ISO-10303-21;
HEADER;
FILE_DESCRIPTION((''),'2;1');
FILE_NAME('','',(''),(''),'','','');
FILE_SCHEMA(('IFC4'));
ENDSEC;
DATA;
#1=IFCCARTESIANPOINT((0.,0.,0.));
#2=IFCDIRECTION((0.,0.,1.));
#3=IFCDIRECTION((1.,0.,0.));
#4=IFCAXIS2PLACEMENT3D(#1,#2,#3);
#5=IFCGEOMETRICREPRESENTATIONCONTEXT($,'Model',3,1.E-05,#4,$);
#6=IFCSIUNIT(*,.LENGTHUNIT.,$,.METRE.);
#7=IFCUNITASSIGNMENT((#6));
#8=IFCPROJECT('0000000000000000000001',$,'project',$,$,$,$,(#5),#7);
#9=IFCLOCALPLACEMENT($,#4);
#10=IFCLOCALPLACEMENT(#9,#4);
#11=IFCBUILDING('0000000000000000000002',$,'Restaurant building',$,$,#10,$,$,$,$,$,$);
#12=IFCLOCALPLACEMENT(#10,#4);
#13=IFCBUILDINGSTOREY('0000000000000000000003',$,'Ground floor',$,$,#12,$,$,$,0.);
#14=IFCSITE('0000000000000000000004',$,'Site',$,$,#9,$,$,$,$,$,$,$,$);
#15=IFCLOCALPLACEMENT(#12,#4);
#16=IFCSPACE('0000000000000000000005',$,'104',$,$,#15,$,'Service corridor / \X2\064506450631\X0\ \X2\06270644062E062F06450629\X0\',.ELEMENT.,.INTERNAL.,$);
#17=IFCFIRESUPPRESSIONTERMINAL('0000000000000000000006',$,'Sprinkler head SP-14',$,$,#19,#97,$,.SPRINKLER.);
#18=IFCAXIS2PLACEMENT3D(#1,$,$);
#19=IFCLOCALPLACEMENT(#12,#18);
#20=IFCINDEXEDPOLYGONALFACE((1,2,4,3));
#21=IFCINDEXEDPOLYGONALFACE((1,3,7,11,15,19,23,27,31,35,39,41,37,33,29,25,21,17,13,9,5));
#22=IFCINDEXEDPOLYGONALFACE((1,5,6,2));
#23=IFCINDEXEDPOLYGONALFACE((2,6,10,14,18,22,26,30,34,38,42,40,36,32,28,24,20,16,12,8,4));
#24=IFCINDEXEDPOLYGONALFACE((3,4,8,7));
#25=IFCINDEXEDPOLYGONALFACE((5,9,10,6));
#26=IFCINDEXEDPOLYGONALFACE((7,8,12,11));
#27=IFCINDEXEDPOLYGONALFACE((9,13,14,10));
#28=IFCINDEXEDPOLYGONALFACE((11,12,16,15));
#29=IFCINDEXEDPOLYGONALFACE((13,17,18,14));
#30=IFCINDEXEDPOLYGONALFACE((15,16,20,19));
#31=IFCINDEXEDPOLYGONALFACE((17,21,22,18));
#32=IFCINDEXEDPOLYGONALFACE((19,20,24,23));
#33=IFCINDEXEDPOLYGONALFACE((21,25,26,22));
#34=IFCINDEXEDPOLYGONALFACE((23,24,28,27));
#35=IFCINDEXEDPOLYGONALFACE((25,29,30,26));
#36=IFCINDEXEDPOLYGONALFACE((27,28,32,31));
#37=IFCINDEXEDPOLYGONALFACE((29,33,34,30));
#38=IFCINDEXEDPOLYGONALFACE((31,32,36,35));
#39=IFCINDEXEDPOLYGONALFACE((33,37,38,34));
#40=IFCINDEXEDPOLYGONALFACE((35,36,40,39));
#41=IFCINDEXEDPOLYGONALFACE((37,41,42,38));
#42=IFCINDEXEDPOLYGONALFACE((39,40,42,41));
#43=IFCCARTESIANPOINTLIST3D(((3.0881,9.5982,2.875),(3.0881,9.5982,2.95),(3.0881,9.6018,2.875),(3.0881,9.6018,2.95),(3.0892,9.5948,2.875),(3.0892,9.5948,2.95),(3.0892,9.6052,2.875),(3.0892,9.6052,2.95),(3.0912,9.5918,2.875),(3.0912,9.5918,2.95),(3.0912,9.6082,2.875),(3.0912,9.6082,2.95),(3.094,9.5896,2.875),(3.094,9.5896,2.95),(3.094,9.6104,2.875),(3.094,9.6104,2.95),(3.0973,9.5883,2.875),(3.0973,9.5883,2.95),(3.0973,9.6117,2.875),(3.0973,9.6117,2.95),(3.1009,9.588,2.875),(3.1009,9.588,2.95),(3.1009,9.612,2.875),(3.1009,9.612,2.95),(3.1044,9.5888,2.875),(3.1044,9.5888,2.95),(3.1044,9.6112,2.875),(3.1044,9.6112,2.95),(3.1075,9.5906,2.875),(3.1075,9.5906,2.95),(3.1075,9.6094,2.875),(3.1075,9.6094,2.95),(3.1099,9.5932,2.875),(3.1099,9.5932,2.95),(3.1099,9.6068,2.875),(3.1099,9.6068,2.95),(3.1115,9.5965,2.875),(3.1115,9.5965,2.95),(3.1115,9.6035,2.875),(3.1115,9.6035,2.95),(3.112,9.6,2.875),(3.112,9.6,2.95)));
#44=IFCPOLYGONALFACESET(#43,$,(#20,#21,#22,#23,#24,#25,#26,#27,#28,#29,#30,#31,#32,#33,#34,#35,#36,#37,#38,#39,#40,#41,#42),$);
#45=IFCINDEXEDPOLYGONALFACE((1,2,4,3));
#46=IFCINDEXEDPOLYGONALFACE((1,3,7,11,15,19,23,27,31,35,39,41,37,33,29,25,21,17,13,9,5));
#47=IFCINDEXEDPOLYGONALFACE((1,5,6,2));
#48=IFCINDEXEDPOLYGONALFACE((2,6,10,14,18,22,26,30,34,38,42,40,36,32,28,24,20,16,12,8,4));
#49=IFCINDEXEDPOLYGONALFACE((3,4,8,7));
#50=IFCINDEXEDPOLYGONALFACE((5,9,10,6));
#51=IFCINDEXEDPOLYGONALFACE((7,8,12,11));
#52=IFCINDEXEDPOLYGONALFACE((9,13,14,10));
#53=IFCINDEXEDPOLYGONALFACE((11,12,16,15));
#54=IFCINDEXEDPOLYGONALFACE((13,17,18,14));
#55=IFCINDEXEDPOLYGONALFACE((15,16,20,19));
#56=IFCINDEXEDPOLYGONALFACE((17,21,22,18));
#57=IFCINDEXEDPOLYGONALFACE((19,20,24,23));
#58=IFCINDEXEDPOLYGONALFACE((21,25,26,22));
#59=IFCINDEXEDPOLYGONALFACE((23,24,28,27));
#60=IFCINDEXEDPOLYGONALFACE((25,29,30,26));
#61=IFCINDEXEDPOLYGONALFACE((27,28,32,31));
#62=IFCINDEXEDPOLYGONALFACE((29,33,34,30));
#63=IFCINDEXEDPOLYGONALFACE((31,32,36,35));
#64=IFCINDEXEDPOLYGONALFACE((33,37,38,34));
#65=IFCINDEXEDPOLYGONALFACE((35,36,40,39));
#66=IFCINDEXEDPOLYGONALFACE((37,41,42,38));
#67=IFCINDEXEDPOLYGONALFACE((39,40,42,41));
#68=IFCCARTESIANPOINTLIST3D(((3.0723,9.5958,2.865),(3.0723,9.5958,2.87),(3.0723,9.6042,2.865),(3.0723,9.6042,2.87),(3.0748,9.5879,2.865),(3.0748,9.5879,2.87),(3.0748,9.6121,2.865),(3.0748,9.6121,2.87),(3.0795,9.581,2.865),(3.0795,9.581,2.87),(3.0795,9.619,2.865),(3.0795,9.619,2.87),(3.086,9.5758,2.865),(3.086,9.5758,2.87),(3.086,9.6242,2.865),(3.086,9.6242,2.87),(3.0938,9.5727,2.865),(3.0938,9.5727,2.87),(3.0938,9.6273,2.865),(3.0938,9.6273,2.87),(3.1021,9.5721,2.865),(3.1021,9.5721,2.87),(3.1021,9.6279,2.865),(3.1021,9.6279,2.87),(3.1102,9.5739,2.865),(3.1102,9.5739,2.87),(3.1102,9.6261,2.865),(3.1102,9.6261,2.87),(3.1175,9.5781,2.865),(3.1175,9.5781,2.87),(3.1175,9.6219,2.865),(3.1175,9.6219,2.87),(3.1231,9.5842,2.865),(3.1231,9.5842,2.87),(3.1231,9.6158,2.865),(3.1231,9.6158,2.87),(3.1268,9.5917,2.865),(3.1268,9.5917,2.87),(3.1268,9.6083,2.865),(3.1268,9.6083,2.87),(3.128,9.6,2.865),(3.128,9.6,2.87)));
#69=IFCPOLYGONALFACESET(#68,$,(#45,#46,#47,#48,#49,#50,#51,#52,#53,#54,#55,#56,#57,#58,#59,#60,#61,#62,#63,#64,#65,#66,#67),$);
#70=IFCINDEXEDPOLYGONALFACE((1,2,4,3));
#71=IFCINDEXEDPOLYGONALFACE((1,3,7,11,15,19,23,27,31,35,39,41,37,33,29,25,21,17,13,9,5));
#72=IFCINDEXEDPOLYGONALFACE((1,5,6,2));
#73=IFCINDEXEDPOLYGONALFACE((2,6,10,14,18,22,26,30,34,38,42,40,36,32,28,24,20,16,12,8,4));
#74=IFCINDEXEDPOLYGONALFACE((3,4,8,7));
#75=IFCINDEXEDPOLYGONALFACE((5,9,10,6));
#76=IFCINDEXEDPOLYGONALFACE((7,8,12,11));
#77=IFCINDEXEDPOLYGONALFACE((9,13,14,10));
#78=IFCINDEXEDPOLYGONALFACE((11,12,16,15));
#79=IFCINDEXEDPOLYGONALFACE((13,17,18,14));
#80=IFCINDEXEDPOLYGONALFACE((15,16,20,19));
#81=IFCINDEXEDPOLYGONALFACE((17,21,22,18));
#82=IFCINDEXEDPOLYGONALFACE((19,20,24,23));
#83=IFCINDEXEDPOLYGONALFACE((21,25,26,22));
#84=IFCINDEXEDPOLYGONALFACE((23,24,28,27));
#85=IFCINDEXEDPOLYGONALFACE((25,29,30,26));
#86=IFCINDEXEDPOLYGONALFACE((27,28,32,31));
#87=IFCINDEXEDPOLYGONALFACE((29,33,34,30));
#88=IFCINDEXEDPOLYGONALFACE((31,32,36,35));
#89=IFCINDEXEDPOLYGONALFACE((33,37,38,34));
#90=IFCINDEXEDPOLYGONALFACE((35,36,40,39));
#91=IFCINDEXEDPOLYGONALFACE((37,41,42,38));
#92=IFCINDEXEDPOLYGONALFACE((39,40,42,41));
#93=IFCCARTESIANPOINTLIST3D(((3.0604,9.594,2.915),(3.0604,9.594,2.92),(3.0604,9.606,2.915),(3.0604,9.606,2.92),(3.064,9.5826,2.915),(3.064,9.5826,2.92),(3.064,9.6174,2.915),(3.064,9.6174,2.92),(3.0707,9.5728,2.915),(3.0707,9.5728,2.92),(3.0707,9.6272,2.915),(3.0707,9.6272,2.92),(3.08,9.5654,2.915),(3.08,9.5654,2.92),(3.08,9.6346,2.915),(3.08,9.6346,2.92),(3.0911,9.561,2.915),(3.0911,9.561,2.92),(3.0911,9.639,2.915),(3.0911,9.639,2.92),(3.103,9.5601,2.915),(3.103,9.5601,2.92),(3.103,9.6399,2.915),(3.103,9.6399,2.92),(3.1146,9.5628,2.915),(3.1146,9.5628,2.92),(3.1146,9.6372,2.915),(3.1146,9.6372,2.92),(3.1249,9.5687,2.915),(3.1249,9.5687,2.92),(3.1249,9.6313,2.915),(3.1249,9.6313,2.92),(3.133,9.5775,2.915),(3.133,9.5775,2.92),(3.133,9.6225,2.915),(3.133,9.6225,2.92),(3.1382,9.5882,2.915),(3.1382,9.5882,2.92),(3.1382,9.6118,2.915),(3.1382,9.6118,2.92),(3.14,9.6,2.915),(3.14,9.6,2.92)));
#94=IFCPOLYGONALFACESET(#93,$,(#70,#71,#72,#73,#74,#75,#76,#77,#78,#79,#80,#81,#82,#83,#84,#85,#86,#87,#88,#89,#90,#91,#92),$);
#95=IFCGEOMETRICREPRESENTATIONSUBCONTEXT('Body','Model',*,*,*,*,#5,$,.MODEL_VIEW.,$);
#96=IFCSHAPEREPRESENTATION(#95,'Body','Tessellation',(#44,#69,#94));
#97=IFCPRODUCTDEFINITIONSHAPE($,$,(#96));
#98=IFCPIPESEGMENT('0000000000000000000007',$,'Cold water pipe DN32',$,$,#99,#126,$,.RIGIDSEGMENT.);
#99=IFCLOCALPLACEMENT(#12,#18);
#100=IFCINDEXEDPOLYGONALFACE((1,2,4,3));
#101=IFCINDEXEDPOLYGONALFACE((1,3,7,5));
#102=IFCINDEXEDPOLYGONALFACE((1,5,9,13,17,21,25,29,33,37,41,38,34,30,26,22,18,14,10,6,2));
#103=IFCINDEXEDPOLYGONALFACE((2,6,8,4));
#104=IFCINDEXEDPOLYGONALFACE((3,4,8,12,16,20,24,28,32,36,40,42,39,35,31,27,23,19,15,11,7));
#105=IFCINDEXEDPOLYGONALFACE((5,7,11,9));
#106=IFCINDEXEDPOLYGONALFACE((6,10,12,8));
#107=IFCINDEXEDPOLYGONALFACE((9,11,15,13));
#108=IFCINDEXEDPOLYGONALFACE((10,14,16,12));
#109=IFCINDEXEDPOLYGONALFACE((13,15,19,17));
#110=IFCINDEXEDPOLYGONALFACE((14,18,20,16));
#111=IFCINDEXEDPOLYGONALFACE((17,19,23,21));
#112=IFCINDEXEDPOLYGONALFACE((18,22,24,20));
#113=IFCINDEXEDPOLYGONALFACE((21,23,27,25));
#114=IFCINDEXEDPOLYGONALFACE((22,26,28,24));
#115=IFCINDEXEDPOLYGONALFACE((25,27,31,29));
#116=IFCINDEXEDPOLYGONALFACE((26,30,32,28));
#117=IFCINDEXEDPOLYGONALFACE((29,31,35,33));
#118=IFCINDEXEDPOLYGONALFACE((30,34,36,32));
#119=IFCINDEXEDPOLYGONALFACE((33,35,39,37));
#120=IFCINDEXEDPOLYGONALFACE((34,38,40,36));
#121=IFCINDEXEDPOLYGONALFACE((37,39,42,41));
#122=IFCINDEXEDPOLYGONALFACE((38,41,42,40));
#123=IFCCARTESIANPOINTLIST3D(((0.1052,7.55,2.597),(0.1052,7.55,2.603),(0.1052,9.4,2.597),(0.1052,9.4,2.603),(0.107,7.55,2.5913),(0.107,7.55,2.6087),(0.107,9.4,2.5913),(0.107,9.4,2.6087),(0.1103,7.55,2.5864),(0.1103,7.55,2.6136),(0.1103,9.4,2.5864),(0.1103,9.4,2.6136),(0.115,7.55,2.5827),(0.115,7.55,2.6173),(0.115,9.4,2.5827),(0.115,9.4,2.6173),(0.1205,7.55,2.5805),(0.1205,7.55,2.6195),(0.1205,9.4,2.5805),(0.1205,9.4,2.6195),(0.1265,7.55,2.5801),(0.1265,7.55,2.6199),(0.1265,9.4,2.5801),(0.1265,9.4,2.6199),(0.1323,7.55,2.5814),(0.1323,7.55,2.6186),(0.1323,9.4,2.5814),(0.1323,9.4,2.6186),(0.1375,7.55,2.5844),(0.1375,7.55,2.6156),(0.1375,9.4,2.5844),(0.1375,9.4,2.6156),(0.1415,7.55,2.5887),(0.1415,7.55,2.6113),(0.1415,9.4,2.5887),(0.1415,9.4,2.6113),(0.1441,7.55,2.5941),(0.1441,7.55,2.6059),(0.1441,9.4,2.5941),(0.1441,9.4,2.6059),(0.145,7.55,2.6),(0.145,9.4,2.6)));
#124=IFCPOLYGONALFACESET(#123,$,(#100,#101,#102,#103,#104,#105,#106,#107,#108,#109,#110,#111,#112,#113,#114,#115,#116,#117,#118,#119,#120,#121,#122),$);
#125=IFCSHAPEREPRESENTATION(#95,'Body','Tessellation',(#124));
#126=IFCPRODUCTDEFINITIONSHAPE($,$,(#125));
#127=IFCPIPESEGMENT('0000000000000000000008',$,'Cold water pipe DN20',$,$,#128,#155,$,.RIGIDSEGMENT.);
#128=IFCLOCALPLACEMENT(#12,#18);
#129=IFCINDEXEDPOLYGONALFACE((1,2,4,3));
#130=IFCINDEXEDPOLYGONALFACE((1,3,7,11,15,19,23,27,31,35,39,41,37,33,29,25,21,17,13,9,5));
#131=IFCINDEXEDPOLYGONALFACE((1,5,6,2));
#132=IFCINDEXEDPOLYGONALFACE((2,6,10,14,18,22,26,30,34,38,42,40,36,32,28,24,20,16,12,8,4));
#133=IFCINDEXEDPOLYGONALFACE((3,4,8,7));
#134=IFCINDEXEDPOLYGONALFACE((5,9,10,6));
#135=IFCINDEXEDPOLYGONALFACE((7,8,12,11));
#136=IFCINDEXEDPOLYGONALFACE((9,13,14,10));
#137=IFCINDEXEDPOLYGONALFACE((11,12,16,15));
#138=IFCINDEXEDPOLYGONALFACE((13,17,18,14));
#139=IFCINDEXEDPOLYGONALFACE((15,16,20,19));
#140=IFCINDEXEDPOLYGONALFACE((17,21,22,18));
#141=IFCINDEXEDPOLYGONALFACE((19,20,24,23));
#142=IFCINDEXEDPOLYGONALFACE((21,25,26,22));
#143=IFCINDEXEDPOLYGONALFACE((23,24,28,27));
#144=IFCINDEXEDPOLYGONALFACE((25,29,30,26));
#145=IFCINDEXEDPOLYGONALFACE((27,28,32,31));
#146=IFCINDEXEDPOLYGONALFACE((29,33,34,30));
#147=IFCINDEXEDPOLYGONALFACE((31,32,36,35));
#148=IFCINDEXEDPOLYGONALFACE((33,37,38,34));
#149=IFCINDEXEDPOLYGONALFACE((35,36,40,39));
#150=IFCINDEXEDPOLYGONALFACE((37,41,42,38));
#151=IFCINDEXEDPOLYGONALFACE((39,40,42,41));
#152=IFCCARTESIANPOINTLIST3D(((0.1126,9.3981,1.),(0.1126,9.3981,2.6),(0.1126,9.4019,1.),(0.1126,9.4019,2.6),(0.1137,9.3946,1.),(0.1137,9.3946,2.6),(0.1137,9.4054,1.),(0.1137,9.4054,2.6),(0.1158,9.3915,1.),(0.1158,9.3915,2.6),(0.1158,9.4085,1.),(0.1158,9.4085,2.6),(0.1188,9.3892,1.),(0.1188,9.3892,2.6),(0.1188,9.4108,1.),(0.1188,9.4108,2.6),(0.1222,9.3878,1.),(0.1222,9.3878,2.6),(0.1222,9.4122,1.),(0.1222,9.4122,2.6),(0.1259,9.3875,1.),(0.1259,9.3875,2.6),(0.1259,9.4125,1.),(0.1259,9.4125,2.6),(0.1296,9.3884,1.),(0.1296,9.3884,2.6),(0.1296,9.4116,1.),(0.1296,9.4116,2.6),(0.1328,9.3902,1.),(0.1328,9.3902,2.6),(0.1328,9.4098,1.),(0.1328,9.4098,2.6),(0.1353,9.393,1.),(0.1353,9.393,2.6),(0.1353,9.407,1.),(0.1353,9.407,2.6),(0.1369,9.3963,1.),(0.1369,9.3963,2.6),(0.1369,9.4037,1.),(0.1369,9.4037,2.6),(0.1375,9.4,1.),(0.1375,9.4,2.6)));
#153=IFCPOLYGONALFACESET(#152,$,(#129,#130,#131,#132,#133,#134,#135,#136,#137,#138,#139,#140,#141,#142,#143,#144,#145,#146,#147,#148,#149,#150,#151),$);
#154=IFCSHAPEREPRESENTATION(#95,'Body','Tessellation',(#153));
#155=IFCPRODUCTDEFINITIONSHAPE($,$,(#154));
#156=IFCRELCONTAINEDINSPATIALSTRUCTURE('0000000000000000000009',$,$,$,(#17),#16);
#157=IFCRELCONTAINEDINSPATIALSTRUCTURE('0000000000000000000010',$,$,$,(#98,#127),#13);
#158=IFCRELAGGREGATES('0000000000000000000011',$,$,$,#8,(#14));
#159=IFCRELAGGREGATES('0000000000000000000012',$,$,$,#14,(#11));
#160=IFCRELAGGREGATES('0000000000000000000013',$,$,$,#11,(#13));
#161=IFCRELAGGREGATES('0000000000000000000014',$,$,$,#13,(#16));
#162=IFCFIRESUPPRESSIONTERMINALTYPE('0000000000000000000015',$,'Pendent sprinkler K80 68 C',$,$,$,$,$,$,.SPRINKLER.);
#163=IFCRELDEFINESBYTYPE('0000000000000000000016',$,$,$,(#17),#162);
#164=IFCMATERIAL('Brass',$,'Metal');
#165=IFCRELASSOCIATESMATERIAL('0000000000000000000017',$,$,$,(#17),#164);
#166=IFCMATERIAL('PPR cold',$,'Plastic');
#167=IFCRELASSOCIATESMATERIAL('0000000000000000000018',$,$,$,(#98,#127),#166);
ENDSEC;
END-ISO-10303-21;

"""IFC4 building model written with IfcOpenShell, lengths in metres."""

from ifc_helpers import new_model, si_unit, frame, origin, origin_with_axes, origin_2d, place, context, subcontext, project, spatial, circle, extrude, source, transform, mapped, material, type_object, type_shapes, element, save


model = new_model("IFC4")

# Units and contexts
model_context = context("Model", 3, precision=1e-05, world=origin_with_axes())
body_context = subcontext(model_context, "Body", "Model", "MODEL_VIEW")
ifc_project = project(units=[si_unit("LENGTHUNIT", "METRE")], contexts=[model_context])

# Site, building, storey
site_placement = place(None, origin_with_axes())
site = spatial("IfcSite", under=ifc_project, at=site_placement, Name="Site")
building_placement = place(site_placement, origin_with_axes())
building = spatial("IfcBuilding", under=site, at=building_placement, Name="Restaurant building")
storey_placement = place(building_placement, origin_with_axes())
storey = spatial("IfcBuildingStorey", under=building, at=storey_placement, Name="Ground floor", Elevation=0.0)

# Shared definitions
ifc_material_1 = material(Name="Brass", Category="Metal")
fire_suppression_terminal_type = type_object("IfcFireSuppressionTerminalType", Name="Pendent sprinkler K80 68 C", PredefinedType="SPRINKLER")
shared_shape_1 = source(origin(), body_context, "Body", "SweptSolid", [
    extrude(circle(Radius=0.012, at=origin_2d()), frame((0.0, 0.0, -0.075)), (0.0, 0.0, 1.0), 0.075),
    extrude(circle(Radius=0.028, at=origin_2d()), frame((0.0, 0.0, -0.085)), (0.0, 0.0, 1.0), 0.005),
    extrude(circle(Radius=0.04, at=origin_2d()), frame((0.0, 0.0, -0.035)), (0.0, 0.0, 1.0), 0.005),
])
type_shapes(fire_suppression_terminal_type, [shared_shape_1])

# Shared definitions
space_1_placement = place(storey_placement, origin_with_axes())
space_1 = spatial("IfcSpace", under=storey, at=space_1_placement, Name="104", LongName="Service corridor / ممر الخدمة", CompositionType="ELEMENT", PredefinedType="INTERNAL")

# Fire suppression terminal
fire_suppression_terminal_1_placement = place(storey_placement, frame((3.1, 9.6, 2.95)))
element("IfcFireSuppressionTerminal", 1, at=fire_suppression_terminal_1_placement, inside=space_1, type_object=fire_suppression_terminal_type, material=ifc_material_1, Name="Sprinkler head SP-14", PredefinedType="SPRINKLER", context=body_context, shape_type="MappedRepresentation", body=[
    mapped(shared_shape_1, transform((0.0, 0.0, 0.0))),
])

# Pipe segments
ifc_material_2 = material(Name="PPR cold", Category="Plastic")
pipe_segment_1_placement = place(storey_placement, frame((0.125, 9.4, 2.6)))
element("IfcPipeSegment", 2, at=pipe_segment_1_placement, inside=storey, material=ifc_material_2, Name="Cold water pipe DN32", PredefinedType="RIGIDSEGMENT", context=body_context, shape_type="SweptSolid", body=[
    extrude(circle(Radius=0.02, at=origin_2d()), frame((0.0, 0.0, 0.0), z_axis=(0.0, -1.0, 0.0), x_axis=(1.0, 0.0, 0.0)), (0.0, 0.0, 1.0), 1.85),
])
pipe_segment_2_placement = place(storey_placement, frame((0.125, 9.4, 2.6)))
element("IfcPipeSegment", 3, at=pipe_segment_2_placement, inside=storey, material=ifc_material_2, Name="Cold water pipe DN20", PredefinedType="RIGIDSEGMENT", context=body_context, shape_type="SweptSolid", body=[
    extrude(circle(Radius=0.0125, at=origin_2d()), frame((0.0, 0.0, 0.0), z_axis=(0.0, 0.0, -1.0), x_axis=(1.0, 0.0, 0.0)), (0.0, 0.0, 1.0), 1.6),
])

save(model, "model.ifc")
